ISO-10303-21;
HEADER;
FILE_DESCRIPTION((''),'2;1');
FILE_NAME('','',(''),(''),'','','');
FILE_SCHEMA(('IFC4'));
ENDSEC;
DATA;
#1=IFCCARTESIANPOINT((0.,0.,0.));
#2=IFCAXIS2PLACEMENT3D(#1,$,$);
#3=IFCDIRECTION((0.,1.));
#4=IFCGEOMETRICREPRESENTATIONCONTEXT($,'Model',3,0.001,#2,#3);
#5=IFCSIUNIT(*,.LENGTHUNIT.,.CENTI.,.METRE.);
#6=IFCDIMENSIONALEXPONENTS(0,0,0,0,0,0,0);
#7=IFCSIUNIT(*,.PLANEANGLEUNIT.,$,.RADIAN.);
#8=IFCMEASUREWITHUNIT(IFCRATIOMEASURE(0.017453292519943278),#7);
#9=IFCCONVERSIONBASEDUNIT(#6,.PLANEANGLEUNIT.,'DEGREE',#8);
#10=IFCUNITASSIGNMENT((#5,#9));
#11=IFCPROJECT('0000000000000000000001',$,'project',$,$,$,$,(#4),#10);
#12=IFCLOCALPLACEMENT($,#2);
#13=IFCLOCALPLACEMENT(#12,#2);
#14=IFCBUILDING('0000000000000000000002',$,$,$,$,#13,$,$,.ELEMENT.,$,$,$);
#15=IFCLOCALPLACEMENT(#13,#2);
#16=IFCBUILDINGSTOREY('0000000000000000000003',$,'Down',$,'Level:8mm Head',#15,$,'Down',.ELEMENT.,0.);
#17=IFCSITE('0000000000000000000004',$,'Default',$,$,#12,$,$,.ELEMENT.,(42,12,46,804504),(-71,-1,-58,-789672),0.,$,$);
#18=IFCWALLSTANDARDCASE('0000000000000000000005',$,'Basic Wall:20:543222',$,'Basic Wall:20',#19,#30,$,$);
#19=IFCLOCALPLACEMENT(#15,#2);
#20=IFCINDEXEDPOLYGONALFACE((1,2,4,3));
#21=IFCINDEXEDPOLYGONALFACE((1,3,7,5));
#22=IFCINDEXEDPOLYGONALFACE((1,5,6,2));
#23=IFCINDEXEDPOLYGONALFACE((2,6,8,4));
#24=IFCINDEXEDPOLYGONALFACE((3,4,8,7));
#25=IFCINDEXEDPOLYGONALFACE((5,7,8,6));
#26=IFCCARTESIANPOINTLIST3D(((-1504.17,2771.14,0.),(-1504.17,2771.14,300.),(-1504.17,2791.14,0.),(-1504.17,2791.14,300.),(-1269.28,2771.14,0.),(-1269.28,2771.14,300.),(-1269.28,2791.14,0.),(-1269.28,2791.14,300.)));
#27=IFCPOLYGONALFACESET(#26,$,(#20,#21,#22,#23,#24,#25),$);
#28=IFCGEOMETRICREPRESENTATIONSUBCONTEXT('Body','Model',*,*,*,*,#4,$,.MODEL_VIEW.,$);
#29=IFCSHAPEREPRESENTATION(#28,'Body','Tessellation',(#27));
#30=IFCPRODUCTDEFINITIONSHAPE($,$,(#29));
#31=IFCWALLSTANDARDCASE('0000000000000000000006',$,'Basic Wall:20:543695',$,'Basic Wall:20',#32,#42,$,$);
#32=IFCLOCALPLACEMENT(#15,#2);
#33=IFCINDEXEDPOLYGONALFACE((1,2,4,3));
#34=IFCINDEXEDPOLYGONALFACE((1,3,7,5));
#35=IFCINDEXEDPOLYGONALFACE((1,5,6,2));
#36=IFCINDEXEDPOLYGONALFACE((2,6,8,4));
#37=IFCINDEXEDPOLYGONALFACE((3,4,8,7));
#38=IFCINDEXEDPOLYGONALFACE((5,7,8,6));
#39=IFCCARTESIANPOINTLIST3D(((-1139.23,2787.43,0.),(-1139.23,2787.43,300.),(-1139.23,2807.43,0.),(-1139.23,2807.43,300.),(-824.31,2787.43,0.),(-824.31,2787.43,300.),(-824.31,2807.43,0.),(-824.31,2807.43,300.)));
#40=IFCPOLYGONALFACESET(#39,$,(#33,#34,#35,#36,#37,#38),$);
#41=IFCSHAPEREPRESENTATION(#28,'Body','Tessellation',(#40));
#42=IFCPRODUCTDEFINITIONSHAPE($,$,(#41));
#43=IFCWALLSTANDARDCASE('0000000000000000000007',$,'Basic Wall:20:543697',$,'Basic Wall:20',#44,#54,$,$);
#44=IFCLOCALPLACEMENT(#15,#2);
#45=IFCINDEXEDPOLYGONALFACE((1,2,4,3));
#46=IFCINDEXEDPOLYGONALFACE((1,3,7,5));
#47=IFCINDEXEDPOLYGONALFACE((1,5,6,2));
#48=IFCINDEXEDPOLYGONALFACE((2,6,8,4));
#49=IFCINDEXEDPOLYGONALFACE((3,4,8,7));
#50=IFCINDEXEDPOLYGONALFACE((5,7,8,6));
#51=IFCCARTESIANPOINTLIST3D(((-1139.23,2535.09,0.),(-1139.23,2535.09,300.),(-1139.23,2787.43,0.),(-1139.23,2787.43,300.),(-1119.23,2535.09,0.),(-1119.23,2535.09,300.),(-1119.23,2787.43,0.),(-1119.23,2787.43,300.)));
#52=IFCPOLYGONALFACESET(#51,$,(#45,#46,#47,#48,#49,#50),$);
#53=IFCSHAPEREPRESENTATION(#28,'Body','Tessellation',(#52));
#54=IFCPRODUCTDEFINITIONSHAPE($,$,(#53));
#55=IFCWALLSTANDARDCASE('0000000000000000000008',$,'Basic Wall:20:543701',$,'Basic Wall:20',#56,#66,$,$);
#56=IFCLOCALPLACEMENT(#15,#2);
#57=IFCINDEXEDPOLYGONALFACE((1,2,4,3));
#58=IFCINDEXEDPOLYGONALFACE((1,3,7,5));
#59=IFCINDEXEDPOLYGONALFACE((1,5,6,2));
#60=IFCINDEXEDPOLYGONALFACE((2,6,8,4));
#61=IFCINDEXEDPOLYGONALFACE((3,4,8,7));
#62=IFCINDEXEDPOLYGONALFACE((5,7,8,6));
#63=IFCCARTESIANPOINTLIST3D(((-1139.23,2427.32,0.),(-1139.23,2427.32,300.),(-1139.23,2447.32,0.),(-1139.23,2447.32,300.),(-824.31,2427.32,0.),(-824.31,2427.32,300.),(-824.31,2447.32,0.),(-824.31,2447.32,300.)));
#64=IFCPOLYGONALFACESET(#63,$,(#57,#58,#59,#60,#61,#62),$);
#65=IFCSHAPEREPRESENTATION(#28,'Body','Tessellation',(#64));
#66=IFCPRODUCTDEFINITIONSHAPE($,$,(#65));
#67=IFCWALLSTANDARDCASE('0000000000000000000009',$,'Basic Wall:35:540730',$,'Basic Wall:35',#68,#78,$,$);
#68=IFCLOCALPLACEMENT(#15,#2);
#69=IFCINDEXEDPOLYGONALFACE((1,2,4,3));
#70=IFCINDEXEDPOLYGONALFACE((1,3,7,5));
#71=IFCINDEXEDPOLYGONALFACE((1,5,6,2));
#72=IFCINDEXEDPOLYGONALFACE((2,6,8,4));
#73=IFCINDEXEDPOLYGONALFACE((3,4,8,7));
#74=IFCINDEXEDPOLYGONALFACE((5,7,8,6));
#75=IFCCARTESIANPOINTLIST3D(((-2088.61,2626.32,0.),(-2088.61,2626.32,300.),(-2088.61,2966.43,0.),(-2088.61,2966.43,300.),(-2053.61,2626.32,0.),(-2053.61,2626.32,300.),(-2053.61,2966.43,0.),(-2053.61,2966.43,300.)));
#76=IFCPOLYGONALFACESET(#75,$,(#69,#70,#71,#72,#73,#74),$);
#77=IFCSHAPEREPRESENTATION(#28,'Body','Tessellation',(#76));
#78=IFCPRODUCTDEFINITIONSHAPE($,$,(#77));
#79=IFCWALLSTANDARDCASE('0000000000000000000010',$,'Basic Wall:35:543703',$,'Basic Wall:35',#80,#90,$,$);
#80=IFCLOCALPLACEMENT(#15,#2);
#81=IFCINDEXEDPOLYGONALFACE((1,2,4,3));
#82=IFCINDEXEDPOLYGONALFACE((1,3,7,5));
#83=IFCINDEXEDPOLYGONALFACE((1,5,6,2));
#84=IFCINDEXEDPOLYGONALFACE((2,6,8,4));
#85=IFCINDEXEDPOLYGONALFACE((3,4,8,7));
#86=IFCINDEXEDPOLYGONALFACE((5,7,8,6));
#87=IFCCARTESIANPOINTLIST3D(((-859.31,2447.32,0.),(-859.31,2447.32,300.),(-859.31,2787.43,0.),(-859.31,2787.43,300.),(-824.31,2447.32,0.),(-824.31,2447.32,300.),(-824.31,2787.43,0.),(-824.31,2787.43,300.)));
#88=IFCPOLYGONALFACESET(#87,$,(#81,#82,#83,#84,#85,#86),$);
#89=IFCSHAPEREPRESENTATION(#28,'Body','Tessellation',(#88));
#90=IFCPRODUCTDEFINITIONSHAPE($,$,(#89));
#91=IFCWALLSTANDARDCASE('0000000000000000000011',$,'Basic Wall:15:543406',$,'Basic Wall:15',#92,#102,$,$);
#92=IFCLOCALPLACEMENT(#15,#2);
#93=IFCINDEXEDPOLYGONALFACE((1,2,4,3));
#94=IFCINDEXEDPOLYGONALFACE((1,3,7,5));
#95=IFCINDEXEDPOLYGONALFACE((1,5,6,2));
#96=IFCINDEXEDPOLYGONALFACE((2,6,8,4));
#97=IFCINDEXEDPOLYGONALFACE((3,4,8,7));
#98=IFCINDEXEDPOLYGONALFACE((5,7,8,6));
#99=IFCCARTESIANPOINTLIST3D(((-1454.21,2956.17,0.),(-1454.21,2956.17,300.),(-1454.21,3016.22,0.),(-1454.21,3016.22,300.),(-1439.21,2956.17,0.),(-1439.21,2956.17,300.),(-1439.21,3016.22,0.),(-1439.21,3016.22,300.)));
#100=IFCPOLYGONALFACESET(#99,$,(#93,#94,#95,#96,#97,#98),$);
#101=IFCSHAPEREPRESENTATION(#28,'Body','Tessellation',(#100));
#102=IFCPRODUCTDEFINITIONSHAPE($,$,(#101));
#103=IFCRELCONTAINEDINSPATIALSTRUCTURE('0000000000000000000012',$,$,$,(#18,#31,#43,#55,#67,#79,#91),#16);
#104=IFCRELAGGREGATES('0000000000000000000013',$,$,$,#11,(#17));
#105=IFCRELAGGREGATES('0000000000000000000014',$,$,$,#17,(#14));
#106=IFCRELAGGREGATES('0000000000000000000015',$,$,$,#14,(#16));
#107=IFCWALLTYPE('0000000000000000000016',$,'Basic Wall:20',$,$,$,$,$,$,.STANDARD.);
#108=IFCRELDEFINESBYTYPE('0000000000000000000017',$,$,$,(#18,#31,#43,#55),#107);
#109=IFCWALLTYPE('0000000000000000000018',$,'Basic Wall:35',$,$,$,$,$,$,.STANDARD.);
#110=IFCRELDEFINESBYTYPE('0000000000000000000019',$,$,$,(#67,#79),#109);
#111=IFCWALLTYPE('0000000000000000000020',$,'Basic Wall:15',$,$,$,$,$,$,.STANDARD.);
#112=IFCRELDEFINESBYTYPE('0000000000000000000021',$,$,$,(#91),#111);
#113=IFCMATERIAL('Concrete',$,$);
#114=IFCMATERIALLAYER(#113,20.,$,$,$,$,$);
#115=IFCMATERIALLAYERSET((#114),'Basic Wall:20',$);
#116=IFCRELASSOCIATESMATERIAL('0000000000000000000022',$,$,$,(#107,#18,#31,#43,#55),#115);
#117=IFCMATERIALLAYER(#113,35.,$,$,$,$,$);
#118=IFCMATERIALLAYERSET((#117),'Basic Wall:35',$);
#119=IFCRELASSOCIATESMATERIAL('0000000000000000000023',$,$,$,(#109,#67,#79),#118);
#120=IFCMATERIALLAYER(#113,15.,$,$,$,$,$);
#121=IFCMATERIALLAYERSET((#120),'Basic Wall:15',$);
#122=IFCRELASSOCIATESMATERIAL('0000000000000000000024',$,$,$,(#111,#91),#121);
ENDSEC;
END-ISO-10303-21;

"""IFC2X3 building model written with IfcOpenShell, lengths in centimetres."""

from ifc_helpers import new_model, entity, si_unit, converted_unit, direction, frame, frame_2d, origin, place, context, subcontext, project, spatial, rectangle, extrude, material, layer, layer_set, layer_usage, type_object, element, save


model = new_model("IFC2X3")

# Units and contexts
model_context = context("Model", 3, precision=0.001, world=origin(), true_north=direction((0.0, 1.0)))
body_context = subcontext(model_context, "Body", "Model", "MODEL_VIEW")
ifc_project = project(units=[si_unit("LENGTHUNIT", "METRE", prefix="CENTI"), converted_unit("PLANEANGLEUNIT", "DEGREE", entity("IfcRatioMeasure", 0.017453292519943278), si_unit("PLANEANGLEUNIT", "RADIAN"), dimensions=[0, 0, 0, 0, 0, 0, 0])], contexts=[model_context])

# Site, building, storey
site_placement = place(None, origin())
site = spatial("IfcSite", under=ifc_project, at=site_placement, Name="Default", CompositionType="ELEMENT", RefLatitude=(42, 12, 46, 804504), RefLongitude=(-71, -1, -58, -789672), RefElevation=0.0)
building_placement = place(site_placement, origin())
building = spatial("IfcBuilding", under=site, at=building_placement, CompositionType="ELEMENT")
storey_placement = place(building_placement, origin())
storey = spatial("IfcBuildingStorey", under=building, at=storey_placement, Name="Down", ObjectType="Level:8mm Head", LongName="Down", CompositionType="ELEMENT", Elevation=0.0)

# Shared definitions
ifc_material = material(Name="Concrete")

# Shared definitions
ifc_layer_1 = layer(ifc_material, 20.0)
ifc_layer_set_1 = layer_set([ifc_layer_1], Name="Basic Wall:20")
wall_type_1 = type_object("IfcWallType", Name="Basic Wall:20", PredefinedType="STANDARD", material=ifc_layer_set_1)

# Walls
ifc_layer_usage_1 = layer_usage(ifc_layer_set_1, "AXIS2", "NEGATIVE", 10.0)
wall_1_placement = place(storey_placement, frame((-1504.17, 2781.14, 0.0)))
element("IfcWallStandardCase", 1, at=wall_1_placement, inside=storey, type_object=wall_type_1, material=ifc_layer_usage_1, Name="Basic Wall:20:543222", ObjectType="Basic Wall:20", context=body_context, shape_type="SweptSolid", body=[
    extrude(rectangle(XDim=234.89, YDim=20.0, at=frame_2d((117.45, 0.0), x_axis=(-1.0, 0.0))), origin(), (0.0, 0.0, 1.0), 300.0),
])
ifc_layer_usage_2 = layer_usage(ifc_layer_set_1, "AXIS2", "POSITIVE", -10.0)
wall_2_placement = place(storey_placement, frame((-824.31, 2797.43, 0.0), z_axis=(0.0, 0.0, 1.0), x_axis=(-1.0, 0.0, 0.0)))
element("IfcWallStandardCase", 2, at=wall_2_placement, inside=storey, type_object=wall_type_1, material=ifc_layer_usage_2, Name="Basic Wall:20:543695", ObjectType="Basic Wall:20", context=body_context, shape_type="SweptSolid", body=[
    extrude(rectangle(XDim=314.92, YDim=20.0, at=frame_2d((157.46, 0.0), x_axis=(-1.0, 0.0))), origin(), (0.0, 0.0, 1.0), 300.0),
])
ifc_layer_usage_3 = layer_usage(ifc_layer_set_1, "AXIS2", "POSITIVE", -10.0)
wall_3_placement = place(storey_placement, frame((-1129.23, 2787.43, 0.0), z_axis=(0.0, 0.0, 1.0), x_axis=(0.0, -1.0, 0.0)))
element("IfcWallStandardCase", 3, at=wall_3_placement, inside=storey, type_object=wall_type_1, material=ifc_layer_usage_3, Name="Basic Wall:20:543697", ObjectType="Basic Wall:20", context=body_context, shape_type="SweptSolid", body=[
    extrude(rectangle(XDim=252.33, YDim=20.0, at=frame_2d((126.17, 0.0), x_axis=(-1.0, 0.0))), origin(), (0.0, 0.0, 1.0), 300.0),
])
ifc_layer_usage_4 = layer_usage(ifc_layer_set_1, "AXIS2", "POSITIVE", -10.0)
wall_4_placement = place(storey_placement, frame((-1139.23, 2437.32, 0.0)))
element("IfcWallStandardCase", 4, at=wall_4_placement, inside=storey, type_object=wall_type_1, material=ifc_layer_usage_4, Name="Basic Wall:20:543701", ObjectType="Basic Wall:20", context=body_context, shape_type="SweptSolid", body=[
    extrude(rectangle(XDim=314.92, YDim=20.0, at=frame_2d((157.46, 0.0), x_axis=(-1.0, 0.0))), origin(), (0.0, 0.0, 1.0), 300.0),
])
ifc_layer_2 = layer(ifc_material, 35.0)
ifc_layer_set_2 = layer_set([ifc_layer_2], Name="Basic Wall:35")
ifc_layer_usage_5 = layer_usage(ifc_layer_set_2, "AXIS2", "NEGATIVE", 17.5)
wall_type_2 = type_object("IfcWallType", Name="Basic Wall:35", PredefinedType="STANDARD", material=ifc_layer_set_2)
wall_5_placement = place(storey_placement, frame((-2071.11, 2626.32, 0.0), z_axis=(0.0, 0.0, 1.0), x_axis=(0.0, 1.0, 0.0)))
element("IfcWallStandardCase", 5, at=wall_5_placement, inside=storey, type_object=wall_type_2, material=ifc_layer_usage_5, Name="Basic Wall:35:540730", ObjectType="Basic Wall:35", context=body_context, shape_type="SweptSolid", body=[
    extrude(rectangle(XDim=340.1, YDim=35.0, at=frame_2d((170.05, 0.0), x_axis=(-1.0, 0.0))), origin(), (0.0, 0.0, 1.0), 300.0),
])
ifc_layer_usage_6 = layer_usage(ifc_layer_set_2, "AXIS2", "POSITIVE", -17.5)
wall_6_placement = place(storey_placement, frame((-841.81, 2447.32, 0.0), z_axis=(0.0, 0.0, 1.0), x_axis=(0.0, 1.0, 0.0)))
element("IfcWallStandardCase", 6, at=wall_6_placement, inside=storey, type_object=wall_type_2, material=ifc_layer_usage_6, Name="Basic Wall:35:543703", ObjectType="Basic Wall:35", context=body_context, shape_type="SweptSolid", body=[
    extrude(rectangle(XDim=340.1, YDim=35.0, at=frame_2d((170.05, 0.0), x_axis=(-1.0, 0.0))), origin(), (0.0, 0.0, 1.0), 300.0),
])
ifc_layer_3 = layer(ifc_material, 15.0)
ifc_layer_set_3 = layer_set([ifc_layer_3], Name="Basic Wall:15")
ifc_layer_usage_7 = layer_usage(ifc_layer_set_3, "AXIS2", "POSITIVE", -7.5)
wall_type_3 = type_object("IfcWallType", Name="Basic Wall:15", PredefinedType="STANDARD", material=ifc_layer_set_3)
wall_7_placement = place(storey_placement, frame((-1446.71, 2956.17, 0.0), z_axis=(0.0, 0.0, 1.0), x_axis=(0.0, 1.0, 0.0)))
element("IfcWallStandardCase", 7, at=wall_7_placement, inside=storey, type_object=wall_type_3, material=ifc_layer_usage_7, Name="Basic Wall:15:543406", ObjectType="Basic Wall:15", context=body_context, shape_type="SweptSolid", body=[
    extrude(rectangle(XDim=60.05, YDim=15.0, at=frame_2d((30.03, 0.0), x_axis=(-1.0, 0.0))), origin(), (0.0, 0.0, 1.0), 300.0),
])

save(model, "model.ifc")
